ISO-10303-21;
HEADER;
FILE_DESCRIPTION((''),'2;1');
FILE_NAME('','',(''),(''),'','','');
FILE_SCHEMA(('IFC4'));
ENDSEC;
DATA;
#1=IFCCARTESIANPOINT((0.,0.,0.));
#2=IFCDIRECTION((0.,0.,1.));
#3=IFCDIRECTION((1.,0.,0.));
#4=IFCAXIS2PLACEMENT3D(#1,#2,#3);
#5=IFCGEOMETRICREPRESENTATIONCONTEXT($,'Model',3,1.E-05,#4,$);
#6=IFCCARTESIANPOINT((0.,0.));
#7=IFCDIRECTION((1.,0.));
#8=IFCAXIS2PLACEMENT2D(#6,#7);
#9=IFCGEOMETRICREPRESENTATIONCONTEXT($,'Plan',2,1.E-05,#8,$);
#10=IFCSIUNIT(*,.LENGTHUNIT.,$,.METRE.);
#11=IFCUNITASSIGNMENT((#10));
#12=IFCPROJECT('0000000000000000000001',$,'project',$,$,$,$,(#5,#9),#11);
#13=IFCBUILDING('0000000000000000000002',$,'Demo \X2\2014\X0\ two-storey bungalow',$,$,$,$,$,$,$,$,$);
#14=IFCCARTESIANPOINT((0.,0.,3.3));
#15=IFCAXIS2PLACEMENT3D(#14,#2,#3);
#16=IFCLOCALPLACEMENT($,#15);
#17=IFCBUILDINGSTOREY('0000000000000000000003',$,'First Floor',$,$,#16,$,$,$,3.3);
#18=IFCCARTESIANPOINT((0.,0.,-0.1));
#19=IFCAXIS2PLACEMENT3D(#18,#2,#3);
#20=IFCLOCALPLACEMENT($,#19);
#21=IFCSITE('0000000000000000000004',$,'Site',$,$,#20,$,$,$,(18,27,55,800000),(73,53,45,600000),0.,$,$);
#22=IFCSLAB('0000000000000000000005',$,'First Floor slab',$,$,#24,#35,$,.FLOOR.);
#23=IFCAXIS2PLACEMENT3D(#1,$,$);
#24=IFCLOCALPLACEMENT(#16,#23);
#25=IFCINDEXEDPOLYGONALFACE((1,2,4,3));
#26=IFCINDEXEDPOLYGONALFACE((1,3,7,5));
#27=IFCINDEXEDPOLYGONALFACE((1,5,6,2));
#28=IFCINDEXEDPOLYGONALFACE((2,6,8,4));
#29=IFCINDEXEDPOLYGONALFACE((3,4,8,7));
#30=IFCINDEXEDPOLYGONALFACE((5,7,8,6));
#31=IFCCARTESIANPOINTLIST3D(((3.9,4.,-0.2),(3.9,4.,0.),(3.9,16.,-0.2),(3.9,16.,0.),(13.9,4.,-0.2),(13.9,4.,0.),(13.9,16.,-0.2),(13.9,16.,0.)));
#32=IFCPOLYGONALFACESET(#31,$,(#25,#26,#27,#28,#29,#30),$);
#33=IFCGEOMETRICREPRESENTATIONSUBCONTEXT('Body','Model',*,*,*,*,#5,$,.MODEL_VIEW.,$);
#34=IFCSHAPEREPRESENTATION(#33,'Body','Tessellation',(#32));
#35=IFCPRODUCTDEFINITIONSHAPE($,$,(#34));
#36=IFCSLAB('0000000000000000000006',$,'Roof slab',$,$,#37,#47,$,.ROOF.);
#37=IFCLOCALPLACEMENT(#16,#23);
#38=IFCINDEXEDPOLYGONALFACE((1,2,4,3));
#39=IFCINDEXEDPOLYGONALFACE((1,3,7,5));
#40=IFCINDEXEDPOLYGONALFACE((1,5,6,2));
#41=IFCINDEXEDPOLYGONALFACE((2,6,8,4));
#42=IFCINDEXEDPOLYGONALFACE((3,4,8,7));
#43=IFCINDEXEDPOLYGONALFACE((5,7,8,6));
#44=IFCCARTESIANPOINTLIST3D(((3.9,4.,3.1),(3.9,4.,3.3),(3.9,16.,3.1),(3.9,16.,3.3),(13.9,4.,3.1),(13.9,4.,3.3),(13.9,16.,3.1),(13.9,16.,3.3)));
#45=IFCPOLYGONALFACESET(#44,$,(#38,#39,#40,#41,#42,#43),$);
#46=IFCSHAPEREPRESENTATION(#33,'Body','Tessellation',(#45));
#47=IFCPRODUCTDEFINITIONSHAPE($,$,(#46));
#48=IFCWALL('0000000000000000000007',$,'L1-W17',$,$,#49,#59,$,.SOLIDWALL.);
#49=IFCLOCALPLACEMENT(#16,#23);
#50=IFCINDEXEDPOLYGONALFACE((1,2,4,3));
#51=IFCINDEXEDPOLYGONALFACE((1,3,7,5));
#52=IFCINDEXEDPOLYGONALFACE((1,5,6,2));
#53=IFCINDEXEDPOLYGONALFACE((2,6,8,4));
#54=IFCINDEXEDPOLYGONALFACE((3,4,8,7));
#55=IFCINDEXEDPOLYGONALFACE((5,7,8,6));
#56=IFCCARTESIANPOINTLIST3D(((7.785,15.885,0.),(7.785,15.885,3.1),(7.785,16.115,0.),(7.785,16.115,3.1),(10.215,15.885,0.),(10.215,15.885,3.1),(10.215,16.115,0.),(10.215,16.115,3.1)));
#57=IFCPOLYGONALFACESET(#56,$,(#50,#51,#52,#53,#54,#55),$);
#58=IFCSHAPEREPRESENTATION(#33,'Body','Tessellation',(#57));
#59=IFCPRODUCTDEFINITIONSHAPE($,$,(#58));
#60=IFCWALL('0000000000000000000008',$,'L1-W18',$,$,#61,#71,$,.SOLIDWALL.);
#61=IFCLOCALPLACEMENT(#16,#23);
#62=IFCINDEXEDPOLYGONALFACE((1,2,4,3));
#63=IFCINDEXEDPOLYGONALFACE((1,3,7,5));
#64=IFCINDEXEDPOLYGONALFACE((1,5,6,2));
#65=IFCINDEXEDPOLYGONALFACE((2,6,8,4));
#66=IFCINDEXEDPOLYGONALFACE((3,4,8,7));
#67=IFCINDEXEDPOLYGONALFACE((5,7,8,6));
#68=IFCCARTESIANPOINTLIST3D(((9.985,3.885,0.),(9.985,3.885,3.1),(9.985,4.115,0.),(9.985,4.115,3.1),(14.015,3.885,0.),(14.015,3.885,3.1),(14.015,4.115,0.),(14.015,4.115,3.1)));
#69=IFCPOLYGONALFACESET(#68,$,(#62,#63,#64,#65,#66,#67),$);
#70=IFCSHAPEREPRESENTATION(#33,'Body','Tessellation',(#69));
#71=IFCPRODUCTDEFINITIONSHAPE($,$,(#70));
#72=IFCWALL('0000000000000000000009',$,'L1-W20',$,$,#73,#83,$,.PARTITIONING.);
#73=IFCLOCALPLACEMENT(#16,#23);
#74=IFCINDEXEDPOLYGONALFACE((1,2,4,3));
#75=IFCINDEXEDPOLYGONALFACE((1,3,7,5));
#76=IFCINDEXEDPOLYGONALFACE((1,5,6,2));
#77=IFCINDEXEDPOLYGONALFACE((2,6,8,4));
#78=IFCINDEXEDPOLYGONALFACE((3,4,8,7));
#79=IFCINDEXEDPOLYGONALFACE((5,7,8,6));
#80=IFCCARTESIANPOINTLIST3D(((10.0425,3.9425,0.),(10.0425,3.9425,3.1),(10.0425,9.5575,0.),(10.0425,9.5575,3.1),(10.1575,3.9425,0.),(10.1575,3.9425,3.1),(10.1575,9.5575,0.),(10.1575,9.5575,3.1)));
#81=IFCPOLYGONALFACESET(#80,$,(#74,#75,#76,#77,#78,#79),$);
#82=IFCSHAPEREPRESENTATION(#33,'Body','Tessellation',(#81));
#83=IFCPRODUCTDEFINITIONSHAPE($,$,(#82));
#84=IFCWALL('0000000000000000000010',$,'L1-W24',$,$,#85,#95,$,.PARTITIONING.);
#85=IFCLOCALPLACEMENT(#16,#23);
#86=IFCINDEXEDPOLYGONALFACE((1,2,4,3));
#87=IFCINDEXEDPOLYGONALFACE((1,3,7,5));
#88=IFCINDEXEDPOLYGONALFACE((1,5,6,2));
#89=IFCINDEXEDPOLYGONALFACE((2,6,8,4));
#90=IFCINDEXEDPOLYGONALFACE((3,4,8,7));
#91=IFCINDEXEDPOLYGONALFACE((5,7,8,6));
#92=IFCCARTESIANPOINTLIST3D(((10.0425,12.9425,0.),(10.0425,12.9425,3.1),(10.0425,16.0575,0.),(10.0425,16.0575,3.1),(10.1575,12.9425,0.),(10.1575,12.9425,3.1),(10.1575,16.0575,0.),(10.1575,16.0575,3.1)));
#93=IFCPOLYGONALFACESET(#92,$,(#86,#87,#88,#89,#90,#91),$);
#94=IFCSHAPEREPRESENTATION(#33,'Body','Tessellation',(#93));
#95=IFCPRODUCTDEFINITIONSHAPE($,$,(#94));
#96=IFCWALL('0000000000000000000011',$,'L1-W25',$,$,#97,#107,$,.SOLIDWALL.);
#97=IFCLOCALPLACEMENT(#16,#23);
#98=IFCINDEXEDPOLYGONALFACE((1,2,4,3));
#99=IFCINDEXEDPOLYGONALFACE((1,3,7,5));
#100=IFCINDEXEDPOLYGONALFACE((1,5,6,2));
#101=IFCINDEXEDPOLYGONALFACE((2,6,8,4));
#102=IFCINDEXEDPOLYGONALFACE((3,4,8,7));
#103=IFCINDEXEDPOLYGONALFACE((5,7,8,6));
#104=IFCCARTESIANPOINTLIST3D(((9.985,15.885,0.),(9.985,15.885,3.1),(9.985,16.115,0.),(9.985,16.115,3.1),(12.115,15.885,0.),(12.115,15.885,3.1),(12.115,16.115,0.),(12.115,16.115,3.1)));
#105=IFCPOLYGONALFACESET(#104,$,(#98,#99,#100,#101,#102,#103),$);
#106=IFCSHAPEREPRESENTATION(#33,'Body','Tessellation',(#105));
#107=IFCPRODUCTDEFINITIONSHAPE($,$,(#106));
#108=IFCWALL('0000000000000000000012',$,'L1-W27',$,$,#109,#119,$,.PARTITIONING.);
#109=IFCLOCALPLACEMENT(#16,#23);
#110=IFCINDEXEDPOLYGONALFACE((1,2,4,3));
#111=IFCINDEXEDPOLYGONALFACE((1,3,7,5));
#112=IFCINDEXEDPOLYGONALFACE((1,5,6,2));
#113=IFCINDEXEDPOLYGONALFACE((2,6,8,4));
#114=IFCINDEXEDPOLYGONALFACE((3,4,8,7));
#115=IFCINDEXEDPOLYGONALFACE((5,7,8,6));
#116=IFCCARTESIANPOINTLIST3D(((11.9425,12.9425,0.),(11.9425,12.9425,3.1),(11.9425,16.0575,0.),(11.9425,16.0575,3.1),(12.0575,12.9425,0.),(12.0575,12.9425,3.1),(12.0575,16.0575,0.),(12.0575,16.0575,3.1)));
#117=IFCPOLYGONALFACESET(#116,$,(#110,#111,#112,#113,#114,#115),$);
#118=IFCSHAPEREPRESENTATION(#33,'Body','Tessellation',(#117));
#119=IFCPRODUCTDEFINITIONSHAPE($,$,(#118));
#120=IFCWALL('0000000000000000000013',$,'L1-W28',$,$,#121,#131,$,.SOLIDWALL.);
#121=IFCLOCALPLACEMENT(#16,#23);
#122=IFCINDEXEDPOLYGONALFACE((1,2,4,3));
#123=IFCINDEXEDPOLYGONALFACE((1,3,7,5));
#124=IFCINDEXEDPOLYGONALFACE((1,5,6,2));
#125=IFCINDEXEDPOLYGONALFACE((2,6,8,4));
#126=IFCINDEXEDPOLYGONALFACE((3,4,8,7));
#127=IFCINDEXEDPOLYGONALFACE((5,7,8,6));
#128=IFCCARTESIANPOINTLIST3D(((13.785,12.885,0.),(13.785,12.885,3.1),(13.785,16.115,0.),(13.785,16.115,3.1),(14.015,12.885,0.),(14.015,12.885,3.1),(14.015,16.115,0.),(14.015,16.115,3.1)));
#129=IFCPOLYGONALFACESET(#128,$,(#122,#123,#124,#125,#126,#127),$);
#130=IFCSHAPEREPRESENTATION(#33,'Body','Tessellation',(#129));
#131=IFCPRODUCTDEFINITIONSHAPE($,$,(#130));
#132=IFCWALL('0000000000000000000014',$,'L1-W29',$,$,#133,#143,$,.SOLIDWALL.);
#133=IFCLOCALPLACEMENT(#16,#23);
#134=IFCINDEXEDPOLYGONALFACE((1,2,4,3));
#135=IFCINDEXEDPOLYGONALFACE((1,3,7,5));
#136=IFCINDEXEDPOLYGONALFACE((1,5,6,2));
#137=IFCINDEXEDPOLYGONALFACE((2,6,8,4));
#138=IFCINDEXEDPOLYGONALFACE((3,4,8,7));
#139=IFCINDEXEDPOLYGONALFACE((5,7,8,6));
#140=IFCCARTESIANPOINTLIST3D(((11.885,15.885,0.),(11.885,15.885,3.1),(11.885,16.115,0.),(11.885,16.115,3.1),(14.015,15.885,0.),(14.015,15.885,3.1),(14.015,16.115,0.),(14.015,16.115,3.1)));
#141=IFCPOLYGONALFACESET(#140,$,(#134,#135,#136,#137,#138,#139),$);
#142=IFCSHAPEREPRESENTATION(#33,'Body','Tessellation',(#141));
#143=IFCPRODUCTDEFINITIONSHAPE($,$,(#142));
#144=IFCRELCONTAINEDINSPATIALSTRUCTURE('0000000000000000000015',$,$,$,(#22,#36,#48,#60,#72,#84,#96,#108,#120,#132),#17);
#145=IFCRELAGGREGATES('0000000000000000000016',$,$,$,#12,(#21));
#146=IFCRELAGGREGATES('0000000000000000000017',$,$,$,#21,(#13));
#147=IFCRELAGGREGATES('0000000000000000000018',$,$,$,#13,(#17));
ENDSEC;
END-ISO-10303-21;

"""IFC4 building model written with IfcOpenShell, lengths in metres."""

from ifc_helpers import new_model, si_unit, frame, origin_with_axes, origin_2d_with_axis, place, context, subcontext, project, spatial, line, indexed_curve, outline, extrude, element, save


model = new_model("IFC4")

# Units and contexts
model_context = context("Model", 3, precision=1e-05, world=origin_with_axes())
plan_context = context("Plan", 2, precision=1e-05, world=origin_2d_with_axis())
body_context = subcontext(model_context, "Body", "Model", "MODEL_VIEW")
ifc_project = project(units=[si_unit("LENGTHUNIT", "METRE")], contexts=[model_context, plan_context])

# Site, building, storey
site_placement = place(None, frame((0.0, 0.0, -0.1), z_axis=(0.0, 0.0, 1.0), x_axis=(1.0, 0.0, 0.0)))
site = spatial("IfcSite", under=ifc_project, at=site_placement, Name="Site", RefLatitude=(18, 27, 55, 800000), RefLongitude=(73, 53, 45, 600000), RefElevation=0.0)
building = spatial("IfcBuilding", under=site, Name="Demo — two-storey bungalow")
storey_placement = place(None, frame((0.0, 0.0, 3.3), z_axis=(0.0, 0.0, 1.0), x_axis=(1.0, 0.0, 0.0)))
storey = spatial("IfcBuildingStorey", under=building, at=storey_placement, Name="First Floor", Elevation=3.3)

# Slabs
slab_1_placement = place(storey_placement, frame((0.0, 0.0, -0.2), z_axis=(0.0, 0.0, 1.0), x_axis=(1.0, 0.0, 0.0)))
element("IfcSlab", 1, at=slab_1_placement, inside=storey, Name="First Floor slab", PredefinedType="FLOOR", context=body_context, shape_type="SweptSolid", body=[
    extrude(outline(indexed_curve([(3.9, 4.0), (13.9, 4.0), (13.9, 16.0), (3.9, 16.0)], segments=[line(1, 2, 3, 4, 1)])), origin_with_axes(), (0.0, 0.0, 1.0), 0.2),
])
slab_2_placement = place(storey_placement, frame((0.0, 0.0, 3.1), z_axis=(0.0, 0.0, 1.0), x_axis=(1.0, 0.0, 0.0)))
element("IfcSlab", 2, at=slab_2_placement, inside=storey, Name="Roof slab", PredefinedType="ROOF", context=body_context, shape_type="SweptSolid", body=[
    extrude(outline(indexed_curve([(3.9, 4.0), (13.9, 4.0), (13.9, 16.0), (3.9, 16.0)], segments=[line(1, 2, 3, 4, 1)])), origin_with_axes(), (0.0, 0.0, 1.0), 0.2),
])

# Walls
wall_1_placement = place(storey_placement, frame((0.0, 0.0, -3.3), z_axis=(0.0, 0.0, 1.0), x_axis=(1.0, 0.0, 0.0)))
element("IfcWall", 3, at=wall_1_placement, inside=storey, Name="L1-W17", PredefinedType="SOLIDWALL", context=body_context, shape_type="SweptSolid", body=[
    extrude(outline(indexed_curve([(10.215, 15.885), (7.785, 15.885), (7.785, 16.115), (10.215, 16.115)], segments=[line(1, 2, 3, 4, 1)])), frame((0.0, 0.0, 3.3), z_axis=(0.0, 0.0, 1.0), x_axis=(1.0, 0.0, 0.0)), (0.0, 0.0, 1.0), 3.1),
])
wall_2_placement = place(storey_placement, frame((0.0, 0.0, -3.3), z_axis=(0.0, 0.0, 1.0), x_axis=(1.0, 0.0, 0.0)))
element("IfcWall", 4, at=wall_2_placement, inside=storey, Name="L1-W18", PredefinedType="SOLIDWALL", context=body_context, shape_type="SweptSolid", body=[
    extrude(outline(indexed_curve([(9.985, 4.115), (14.015, 4.115), (14.015, 3.885), (9.985, 3.885)], segments=[line(1, 2, 3, 4, 1)])), frame((0.0, 0.0, 3.3), z_axis=(0.0, 0.0, 1.0), x_axis=(1.0, 0.0, 0.0)), (0.0, 0.0, 1.0), 3.1),
])

# Wall
wall_3_placement = place(storey_placement, frame((0.0, 0.0, -3.3), z_axis=(0.0, 0.0, 1.0), x_axis=(1.0, 0.0, 0.0)))
element("IfcWall", 5, at=wall_3_placement, inside=storey, Name="L1-W20", PredefinedType="PARTITIONING", context=body_context, shape_type="SweptSolid", body=[
    extrude(outline(indexed_curve([(10.0425, 3.9425), (10.0425, 9.5575), (10.1575, 9.5575), (10.1575, 3.9425)], segments=[line(1, 2, 3, 4, 1)])), frame((0.0, 0.0, 3.3), z_axis=(0.0, 0.0, 1.0), x_axis=(1.0, 0.0, 0.0)), (0.0, 0.0, 1.0), 3.1),
])

# Walls
wall_4_placement = place(storey_placement, frame((0.0, 0.0, -3.3), z_axis=(0.0, 0.0, 1.0), x_axis=(1.0, 0.0, 0.0)))
element("IfcWall", 6, at=wall_4_placement, inside=storey, Name="L1-W24", PredefinedType="PARTITIONING", context=body_context, shape_type="SweptSolid", body=[
    extrude(outline(indexed_curve([(10.0425, 12.9425), (10.0425, 16.0575), (10.1575, 16.0575), (10.1575, 12.9425)], segments=[line(1, 2, 3, 4, 1)])), frame((0.0, 0.0, 3.3), z_axis=(0.0, 0.0, 1.0), x_axis=(1.0, 0.0, 0.0)), (0.0, 0.0, 1.0), 3.1),
])
wall_5_placement = place(storey_placement, frame((0.0, 0.0, -3.3), z_axis=(0.0, 0.0, 1.0), x_axis=(1.0, 0.0, 0.0)))
element("IfcWall", 7, at=wall_5_placement, inside=storey, Name="L1-W25", PredefinedType="SOLIDWALL", context=body_context, shape_type="SweptSolid", body=[
    extrude(outline(indexed_curve([(12.115, 15.885), (9.985, 15.885), (9.985, 16.115), (12.115, 16.115)], segments=[line(1, 2, 3, 4, 1)])), frame((0.0, 0.0, 3.3), z_axis=(0.0, 0.0, 1.0), x_axis=(1.0, 0.0, 0.0)), (0.0, 0.0, 1.0), 3.1),
])

# Walls
wall_6_placement = place(storey_placement, frame((0.0, 0.0, -3.3), z_axis=(0.0, 0.0, 1.0), x_axis=(1.0, 0.0, 0.0)))
element("IfcWall", 8, at=wall_6_placement, inside=storey, Name="L1-W27", PredefinedType="PARTITIONING", context=body_context, shape_type="SweptSolid", body=[
    extrude(outline(indexed_curve([(11.9425, 12.9425), (11.9425, 16.0575), (12.0575, 16.0575), (12.0575, 12.9425)], segments=[line(1, 2, 3, 4, 1)])), frame((0.0, 0.0, 3.3), z_axis=(0.0, 0.0, 1.0), x_axis=(1.0, 0.0, 0.0)), (0.0, 0.0, 1.0), 3.1),
])
wall_7_placement = place(storey_placement, frame((0.0, 0.0, -3.3), z_axis=(0.0, 0.0, 1.0), x_axis=(1.0, 0.0, 0.0)))
element("IfcWall", 9, at=wall_7_placement, inside=storey, Name="L1-W28", PredefinedType="SOLIDWALL", context=body_context, shape_type="SweptSolid", body=[
    extrude(outline(indexed_curve([(13.785, 12.885), (13.785, 16.115), (14.015, 16.115), (14.015, 12.885)], segments=[line(1, 2, 3, 4, 1)])), frame((0.0, 0.0, 3.3), z_axis=(0.0, 0.0, 1.0), x_axis=(1.0, 0.0, 0.0)), (0.0, 0.0, 1.0), 3.1),
])
wall_8_placement = place(storey_placement, frame((0.0, 0.0, -3.3), z_axis=(0.0, 0.0, 1.0), x_axis=(1.0, 0.0, 0.0)))
element("IfcWall", 10, at=wall_8_placement, inside=storey, Name="L1-W29", PredefinedType="SOLIDWALL", context=body_context, shape_type="SweptSolid", body=[
    extrude(outline(indexed_curve([(14.015, 15.885), (11.885, 15.885), (11.885, 16.115), (14.015, 16.115)], segments=[line(1, 2, 3, 4, 1)])), frame((0.0, 0.0, 3.3), z_axis=(0.0, 0.0, 1.0), x_axis=(1.0, 0.0, 0.0)), (0.0, 0.0, 1.0), 3.1),
])

save(model, "model.ifc")
